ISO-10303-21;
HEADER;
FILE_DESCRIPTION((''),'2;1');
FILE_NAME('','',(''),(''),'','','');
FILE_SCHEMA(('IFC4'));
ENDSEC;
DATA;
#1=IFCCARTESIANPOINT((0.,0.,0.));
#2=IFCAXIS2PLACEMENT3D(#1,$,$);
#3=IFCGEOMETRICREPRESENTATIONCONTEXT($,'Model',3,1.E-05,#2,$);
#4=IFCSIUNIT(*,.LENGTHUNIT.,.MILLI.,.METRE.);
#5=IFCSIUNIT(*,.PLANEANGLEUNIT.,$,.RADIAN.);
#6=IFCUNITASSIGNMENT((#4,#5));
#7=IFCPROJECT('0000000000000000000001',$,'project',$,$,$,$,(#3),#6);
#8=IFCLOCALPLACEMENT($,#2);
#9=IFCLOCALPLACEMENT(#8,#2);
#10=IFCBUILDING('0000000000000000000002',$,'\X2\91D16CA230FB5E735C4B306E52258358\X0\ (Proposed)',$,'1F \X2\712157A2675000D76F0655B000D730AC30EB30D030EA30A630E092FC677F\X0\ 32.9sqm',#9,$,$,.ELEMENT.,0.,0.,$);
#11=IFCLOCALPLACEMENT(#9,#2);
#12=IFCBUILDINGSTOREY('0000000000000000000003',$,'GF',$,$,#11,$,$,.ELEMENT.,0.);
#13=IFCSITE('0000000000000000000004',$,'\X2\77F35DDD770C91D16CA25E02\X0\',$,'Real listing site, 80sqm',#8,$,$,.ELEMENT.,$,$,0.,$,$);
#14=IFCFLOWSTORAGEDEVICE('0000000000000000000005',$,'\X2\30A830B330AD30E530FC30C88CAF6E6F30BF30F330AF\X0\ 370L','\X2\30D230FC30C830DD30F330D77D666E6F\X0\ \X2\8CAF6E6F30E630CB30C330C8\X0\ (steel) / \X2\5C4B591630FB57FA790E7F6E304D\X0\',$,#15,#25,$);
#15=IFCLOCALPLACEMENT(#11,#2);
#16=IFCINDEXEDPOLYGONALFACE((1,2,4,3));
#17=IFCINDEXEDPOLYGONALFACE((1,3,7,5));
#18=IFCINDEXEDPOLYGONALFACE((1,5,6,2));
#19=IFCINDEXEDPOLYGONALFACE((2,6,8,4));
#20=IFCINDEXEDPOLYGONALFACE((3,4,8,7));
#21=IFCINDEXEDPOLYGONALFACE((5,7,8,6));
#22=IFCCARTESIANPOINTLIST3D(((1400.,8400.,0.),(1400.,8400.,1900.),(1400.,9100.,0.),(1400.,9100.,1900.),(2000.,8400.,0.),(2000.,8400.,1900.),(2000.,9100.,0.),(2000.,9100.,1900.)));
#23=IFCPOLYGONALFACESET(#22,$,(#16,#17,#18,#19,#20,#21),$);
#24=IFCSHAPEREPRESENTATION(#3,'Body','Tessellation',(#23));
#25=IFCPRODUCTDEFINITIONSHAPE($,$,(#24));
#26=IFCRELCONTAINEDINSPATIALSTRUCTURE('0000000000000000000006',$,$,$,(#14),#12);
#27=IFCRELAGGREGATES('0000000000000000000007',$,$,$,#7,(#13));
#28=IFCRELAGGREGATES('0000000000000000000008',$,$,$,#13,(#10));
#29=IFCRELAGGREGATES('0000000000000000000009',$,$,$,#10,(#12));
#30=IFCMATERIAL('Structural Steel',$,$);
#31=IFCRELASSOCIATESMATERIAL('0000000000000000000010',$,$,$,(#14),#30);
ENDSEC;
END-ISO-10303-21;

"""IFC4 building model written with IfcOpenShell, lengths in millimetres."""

from ifc_helpers import new_model, si_unit, frame, frame_2d, origin, place, context, project, spatial, rectangle, extrude, material, element, save


model = new_model("IFC4")

# Units and contexts
model_context = context("Model", 3, precision=1e-05, world=origin())
ifc_project = project(units=[si_unit("LENGTHUNIT", "METRE", prefix="MILLI"), si_unit("PLANEANGLEUNIT", "RADIAN")], contexts=[model_context])

# Site, building, storey
site_placement = place(None, origin())
site = spatial("IfcSite", under=ifc_project, at=site_placement, Name="石川県金沢市", ObjectType="Real listing site, 80sqm", CompositionType="ELEMENT", RefElevation=0.0)
building_placement = place(site_placement, origin())
building = spatial("IfcBuilding", under=site, at=building_placement, Name="金沢・平屋の別荘 (Proposed)", ObjectType="1F 無垢材×漆喰×ガルバリウム鋼板 32.9sqm", CompositionType="ELEMENT", ElevationOfRefHeight=0.0, ElevationOfTerrain=0.0)
storey_placement = place(building_placement, origin())
storey = spatial("IfcBuildingStorey", under=building, at=storey_placement, Name="GF", CompositionType="ELEMENT", Elevation=0.0)

# Shared definitions
ifc_material_1 = material(Name="Structural Steel")

# Flow storage device
flow_storage_device_placement = place(storey_placement, frame((700.0, 4200.0, 0.0)))
element("IfcFlowStorageDevice", 1, at=flow_storage_device_placement, inside=storey, material=ifc_material_1, Name="エコキュート貯湯タンク 370L", Description="ヒートポンプ給湯 貯湯ユニット (steel) / 屋外・基礎置き", context=model_context, shape_type="SweptSolid", body=[
    extrude(rectangle(XDim=600.0, YDim=700.0, at=frame_2d((300.0, 350.0))), frame((700.0, 4200.0, 0.0)), (0.0, 0.0, 1.0), 1900.0),
])

save(model, "model.ifc")
